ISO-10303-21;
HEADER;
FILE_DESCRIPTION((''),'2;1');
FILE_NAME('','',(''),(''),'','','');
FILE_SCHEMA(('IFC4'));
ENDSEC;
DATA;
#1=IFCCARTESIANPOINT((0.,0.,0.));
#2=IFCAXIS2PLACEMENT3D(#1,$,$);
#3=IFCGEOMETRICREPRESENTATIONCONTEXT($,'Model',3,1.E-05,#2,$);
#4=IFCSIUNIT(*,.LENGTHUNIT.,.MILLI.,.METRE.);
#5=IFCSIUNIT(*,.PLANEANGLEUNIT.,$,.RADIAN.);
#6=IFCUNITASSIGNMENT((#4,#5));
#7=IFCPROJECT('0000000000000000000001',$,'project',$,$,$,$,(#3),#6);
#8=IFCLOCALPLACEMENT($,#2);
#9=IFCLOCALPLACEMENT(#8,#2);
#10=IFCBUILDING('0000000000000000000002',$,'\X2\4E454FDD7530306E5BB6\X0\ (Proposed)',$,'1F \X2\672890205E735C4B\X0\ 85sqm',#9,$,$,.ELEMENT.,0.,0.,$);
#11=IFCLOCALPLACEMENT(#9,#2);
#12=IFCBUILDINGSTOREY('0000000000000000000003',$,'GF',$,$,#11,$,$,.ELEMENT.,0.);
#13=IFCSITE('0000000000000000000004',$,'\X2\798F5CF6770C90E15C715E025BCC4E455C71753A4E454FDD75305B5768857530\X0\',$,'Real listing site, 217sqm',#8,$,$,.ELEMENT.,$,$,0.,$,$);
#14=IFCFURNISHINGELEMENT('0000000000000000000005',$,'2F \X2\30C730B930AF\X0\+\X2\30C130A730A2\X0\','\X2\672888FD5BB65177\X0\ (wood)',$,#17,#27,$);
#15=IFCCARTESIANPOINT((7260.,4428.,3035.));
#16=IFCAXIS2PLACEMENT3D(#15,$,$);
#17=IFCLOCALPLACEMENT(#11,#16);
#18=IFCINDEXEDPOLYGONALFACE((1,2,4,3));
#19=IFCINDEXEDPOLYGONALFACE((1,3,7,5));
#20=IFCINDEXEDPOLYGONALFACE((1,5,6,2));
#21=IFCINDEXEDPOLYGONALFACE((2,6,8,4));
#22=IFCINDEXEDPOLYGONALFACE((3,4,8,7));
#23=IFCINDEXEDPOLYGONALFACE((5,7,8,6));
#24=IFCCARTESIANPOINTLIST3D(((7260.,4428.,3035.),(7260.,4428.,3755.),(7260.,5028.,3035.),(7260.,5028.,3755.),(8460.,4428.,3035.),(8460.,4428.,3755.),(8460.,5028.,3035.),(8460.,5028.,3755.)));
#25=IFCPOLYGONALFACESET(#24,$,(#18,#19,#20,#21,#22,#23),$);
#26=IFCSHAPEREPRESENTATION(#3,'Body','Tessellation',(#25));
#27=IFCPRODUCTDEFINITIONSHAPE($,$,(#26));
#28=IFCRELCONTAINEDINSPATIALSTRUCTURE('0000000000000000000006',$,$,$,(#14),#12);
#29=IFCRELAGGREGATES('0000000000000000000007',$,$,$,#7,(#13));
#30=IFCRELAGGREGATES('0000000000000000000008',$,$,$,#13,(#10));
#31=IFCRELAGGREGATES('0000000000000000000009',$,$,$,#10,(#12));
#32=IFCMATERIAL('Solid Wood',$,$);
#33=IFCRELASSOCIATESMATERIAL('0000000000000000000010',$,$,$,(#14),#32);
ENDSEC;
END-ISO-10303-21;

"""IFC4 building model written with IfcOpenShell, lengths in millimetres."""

from ifc_helpers import new_model, si_unit, frame, frame_2d, origin, place, context, project, spatial, rectangle, extrude, material, element, save


model = new_model("IFC4")

# Units and contexts
model_context = context("Model", 3, precision=1e-05, world=origin())
ifc_project = project(units=[si_unit("LENGTHUNIT", "METRE", prefix="MILLI"), si_unit("PLANEANGLEUNIT", "RADIAN")], contexts=[model_context])

# Site, building, storey
site_placement = place(None, origin())
site = spatial("IfcSite", under=ifc_project, at=site_placement, Name="福島県郡山市富久山町久保田字梅田", ObjectType="Real listing site, 217sqm", CompositionType="ELEMENT", RefElevation=0.0)
building_placement = place(site_placement, origin())
building = spatial("IfcBuilding", under=site, at=building_placement, Name="久保田の家 (Proposed)", ObjectType="1F 木造平屋 85sqm", CompositionType="ELEMENT", ElevationOfRefHeight=0.0, ElevationOfTerrain=0.0)
storey_placement = place(building_placement, origin())
storey = spatial("IfcBuildingStorey", under=building, at=storey_placement, Name="GF", CompositionType="ELEMENT", Elevation=0.0)

# Shared definitions
ifc_material_1 = material(Name="Solid Wood")

# Furnishing element
furnishing_1_placement = place(storey_placement, frame((7260.0, 4428.0, 3035.0)))
element("IfcFurnishingElement", 1, at=furnishing_1_placement, inside=storey, material=ifc_material_1, Name="2F デスク+チェア", Description="木製家具 (wood)", context=model_context, shape_type="SweptSolid", body=[
    extrude(rectangle(XDim=1200.0, YDim=600.0, at=frame_2d((600.0, 300.0))), frame((7260.0, 4428.0, 3035.0)), (0.0, 0.0, 1.0), 720.0),
])

save(model, "model.ifc")
